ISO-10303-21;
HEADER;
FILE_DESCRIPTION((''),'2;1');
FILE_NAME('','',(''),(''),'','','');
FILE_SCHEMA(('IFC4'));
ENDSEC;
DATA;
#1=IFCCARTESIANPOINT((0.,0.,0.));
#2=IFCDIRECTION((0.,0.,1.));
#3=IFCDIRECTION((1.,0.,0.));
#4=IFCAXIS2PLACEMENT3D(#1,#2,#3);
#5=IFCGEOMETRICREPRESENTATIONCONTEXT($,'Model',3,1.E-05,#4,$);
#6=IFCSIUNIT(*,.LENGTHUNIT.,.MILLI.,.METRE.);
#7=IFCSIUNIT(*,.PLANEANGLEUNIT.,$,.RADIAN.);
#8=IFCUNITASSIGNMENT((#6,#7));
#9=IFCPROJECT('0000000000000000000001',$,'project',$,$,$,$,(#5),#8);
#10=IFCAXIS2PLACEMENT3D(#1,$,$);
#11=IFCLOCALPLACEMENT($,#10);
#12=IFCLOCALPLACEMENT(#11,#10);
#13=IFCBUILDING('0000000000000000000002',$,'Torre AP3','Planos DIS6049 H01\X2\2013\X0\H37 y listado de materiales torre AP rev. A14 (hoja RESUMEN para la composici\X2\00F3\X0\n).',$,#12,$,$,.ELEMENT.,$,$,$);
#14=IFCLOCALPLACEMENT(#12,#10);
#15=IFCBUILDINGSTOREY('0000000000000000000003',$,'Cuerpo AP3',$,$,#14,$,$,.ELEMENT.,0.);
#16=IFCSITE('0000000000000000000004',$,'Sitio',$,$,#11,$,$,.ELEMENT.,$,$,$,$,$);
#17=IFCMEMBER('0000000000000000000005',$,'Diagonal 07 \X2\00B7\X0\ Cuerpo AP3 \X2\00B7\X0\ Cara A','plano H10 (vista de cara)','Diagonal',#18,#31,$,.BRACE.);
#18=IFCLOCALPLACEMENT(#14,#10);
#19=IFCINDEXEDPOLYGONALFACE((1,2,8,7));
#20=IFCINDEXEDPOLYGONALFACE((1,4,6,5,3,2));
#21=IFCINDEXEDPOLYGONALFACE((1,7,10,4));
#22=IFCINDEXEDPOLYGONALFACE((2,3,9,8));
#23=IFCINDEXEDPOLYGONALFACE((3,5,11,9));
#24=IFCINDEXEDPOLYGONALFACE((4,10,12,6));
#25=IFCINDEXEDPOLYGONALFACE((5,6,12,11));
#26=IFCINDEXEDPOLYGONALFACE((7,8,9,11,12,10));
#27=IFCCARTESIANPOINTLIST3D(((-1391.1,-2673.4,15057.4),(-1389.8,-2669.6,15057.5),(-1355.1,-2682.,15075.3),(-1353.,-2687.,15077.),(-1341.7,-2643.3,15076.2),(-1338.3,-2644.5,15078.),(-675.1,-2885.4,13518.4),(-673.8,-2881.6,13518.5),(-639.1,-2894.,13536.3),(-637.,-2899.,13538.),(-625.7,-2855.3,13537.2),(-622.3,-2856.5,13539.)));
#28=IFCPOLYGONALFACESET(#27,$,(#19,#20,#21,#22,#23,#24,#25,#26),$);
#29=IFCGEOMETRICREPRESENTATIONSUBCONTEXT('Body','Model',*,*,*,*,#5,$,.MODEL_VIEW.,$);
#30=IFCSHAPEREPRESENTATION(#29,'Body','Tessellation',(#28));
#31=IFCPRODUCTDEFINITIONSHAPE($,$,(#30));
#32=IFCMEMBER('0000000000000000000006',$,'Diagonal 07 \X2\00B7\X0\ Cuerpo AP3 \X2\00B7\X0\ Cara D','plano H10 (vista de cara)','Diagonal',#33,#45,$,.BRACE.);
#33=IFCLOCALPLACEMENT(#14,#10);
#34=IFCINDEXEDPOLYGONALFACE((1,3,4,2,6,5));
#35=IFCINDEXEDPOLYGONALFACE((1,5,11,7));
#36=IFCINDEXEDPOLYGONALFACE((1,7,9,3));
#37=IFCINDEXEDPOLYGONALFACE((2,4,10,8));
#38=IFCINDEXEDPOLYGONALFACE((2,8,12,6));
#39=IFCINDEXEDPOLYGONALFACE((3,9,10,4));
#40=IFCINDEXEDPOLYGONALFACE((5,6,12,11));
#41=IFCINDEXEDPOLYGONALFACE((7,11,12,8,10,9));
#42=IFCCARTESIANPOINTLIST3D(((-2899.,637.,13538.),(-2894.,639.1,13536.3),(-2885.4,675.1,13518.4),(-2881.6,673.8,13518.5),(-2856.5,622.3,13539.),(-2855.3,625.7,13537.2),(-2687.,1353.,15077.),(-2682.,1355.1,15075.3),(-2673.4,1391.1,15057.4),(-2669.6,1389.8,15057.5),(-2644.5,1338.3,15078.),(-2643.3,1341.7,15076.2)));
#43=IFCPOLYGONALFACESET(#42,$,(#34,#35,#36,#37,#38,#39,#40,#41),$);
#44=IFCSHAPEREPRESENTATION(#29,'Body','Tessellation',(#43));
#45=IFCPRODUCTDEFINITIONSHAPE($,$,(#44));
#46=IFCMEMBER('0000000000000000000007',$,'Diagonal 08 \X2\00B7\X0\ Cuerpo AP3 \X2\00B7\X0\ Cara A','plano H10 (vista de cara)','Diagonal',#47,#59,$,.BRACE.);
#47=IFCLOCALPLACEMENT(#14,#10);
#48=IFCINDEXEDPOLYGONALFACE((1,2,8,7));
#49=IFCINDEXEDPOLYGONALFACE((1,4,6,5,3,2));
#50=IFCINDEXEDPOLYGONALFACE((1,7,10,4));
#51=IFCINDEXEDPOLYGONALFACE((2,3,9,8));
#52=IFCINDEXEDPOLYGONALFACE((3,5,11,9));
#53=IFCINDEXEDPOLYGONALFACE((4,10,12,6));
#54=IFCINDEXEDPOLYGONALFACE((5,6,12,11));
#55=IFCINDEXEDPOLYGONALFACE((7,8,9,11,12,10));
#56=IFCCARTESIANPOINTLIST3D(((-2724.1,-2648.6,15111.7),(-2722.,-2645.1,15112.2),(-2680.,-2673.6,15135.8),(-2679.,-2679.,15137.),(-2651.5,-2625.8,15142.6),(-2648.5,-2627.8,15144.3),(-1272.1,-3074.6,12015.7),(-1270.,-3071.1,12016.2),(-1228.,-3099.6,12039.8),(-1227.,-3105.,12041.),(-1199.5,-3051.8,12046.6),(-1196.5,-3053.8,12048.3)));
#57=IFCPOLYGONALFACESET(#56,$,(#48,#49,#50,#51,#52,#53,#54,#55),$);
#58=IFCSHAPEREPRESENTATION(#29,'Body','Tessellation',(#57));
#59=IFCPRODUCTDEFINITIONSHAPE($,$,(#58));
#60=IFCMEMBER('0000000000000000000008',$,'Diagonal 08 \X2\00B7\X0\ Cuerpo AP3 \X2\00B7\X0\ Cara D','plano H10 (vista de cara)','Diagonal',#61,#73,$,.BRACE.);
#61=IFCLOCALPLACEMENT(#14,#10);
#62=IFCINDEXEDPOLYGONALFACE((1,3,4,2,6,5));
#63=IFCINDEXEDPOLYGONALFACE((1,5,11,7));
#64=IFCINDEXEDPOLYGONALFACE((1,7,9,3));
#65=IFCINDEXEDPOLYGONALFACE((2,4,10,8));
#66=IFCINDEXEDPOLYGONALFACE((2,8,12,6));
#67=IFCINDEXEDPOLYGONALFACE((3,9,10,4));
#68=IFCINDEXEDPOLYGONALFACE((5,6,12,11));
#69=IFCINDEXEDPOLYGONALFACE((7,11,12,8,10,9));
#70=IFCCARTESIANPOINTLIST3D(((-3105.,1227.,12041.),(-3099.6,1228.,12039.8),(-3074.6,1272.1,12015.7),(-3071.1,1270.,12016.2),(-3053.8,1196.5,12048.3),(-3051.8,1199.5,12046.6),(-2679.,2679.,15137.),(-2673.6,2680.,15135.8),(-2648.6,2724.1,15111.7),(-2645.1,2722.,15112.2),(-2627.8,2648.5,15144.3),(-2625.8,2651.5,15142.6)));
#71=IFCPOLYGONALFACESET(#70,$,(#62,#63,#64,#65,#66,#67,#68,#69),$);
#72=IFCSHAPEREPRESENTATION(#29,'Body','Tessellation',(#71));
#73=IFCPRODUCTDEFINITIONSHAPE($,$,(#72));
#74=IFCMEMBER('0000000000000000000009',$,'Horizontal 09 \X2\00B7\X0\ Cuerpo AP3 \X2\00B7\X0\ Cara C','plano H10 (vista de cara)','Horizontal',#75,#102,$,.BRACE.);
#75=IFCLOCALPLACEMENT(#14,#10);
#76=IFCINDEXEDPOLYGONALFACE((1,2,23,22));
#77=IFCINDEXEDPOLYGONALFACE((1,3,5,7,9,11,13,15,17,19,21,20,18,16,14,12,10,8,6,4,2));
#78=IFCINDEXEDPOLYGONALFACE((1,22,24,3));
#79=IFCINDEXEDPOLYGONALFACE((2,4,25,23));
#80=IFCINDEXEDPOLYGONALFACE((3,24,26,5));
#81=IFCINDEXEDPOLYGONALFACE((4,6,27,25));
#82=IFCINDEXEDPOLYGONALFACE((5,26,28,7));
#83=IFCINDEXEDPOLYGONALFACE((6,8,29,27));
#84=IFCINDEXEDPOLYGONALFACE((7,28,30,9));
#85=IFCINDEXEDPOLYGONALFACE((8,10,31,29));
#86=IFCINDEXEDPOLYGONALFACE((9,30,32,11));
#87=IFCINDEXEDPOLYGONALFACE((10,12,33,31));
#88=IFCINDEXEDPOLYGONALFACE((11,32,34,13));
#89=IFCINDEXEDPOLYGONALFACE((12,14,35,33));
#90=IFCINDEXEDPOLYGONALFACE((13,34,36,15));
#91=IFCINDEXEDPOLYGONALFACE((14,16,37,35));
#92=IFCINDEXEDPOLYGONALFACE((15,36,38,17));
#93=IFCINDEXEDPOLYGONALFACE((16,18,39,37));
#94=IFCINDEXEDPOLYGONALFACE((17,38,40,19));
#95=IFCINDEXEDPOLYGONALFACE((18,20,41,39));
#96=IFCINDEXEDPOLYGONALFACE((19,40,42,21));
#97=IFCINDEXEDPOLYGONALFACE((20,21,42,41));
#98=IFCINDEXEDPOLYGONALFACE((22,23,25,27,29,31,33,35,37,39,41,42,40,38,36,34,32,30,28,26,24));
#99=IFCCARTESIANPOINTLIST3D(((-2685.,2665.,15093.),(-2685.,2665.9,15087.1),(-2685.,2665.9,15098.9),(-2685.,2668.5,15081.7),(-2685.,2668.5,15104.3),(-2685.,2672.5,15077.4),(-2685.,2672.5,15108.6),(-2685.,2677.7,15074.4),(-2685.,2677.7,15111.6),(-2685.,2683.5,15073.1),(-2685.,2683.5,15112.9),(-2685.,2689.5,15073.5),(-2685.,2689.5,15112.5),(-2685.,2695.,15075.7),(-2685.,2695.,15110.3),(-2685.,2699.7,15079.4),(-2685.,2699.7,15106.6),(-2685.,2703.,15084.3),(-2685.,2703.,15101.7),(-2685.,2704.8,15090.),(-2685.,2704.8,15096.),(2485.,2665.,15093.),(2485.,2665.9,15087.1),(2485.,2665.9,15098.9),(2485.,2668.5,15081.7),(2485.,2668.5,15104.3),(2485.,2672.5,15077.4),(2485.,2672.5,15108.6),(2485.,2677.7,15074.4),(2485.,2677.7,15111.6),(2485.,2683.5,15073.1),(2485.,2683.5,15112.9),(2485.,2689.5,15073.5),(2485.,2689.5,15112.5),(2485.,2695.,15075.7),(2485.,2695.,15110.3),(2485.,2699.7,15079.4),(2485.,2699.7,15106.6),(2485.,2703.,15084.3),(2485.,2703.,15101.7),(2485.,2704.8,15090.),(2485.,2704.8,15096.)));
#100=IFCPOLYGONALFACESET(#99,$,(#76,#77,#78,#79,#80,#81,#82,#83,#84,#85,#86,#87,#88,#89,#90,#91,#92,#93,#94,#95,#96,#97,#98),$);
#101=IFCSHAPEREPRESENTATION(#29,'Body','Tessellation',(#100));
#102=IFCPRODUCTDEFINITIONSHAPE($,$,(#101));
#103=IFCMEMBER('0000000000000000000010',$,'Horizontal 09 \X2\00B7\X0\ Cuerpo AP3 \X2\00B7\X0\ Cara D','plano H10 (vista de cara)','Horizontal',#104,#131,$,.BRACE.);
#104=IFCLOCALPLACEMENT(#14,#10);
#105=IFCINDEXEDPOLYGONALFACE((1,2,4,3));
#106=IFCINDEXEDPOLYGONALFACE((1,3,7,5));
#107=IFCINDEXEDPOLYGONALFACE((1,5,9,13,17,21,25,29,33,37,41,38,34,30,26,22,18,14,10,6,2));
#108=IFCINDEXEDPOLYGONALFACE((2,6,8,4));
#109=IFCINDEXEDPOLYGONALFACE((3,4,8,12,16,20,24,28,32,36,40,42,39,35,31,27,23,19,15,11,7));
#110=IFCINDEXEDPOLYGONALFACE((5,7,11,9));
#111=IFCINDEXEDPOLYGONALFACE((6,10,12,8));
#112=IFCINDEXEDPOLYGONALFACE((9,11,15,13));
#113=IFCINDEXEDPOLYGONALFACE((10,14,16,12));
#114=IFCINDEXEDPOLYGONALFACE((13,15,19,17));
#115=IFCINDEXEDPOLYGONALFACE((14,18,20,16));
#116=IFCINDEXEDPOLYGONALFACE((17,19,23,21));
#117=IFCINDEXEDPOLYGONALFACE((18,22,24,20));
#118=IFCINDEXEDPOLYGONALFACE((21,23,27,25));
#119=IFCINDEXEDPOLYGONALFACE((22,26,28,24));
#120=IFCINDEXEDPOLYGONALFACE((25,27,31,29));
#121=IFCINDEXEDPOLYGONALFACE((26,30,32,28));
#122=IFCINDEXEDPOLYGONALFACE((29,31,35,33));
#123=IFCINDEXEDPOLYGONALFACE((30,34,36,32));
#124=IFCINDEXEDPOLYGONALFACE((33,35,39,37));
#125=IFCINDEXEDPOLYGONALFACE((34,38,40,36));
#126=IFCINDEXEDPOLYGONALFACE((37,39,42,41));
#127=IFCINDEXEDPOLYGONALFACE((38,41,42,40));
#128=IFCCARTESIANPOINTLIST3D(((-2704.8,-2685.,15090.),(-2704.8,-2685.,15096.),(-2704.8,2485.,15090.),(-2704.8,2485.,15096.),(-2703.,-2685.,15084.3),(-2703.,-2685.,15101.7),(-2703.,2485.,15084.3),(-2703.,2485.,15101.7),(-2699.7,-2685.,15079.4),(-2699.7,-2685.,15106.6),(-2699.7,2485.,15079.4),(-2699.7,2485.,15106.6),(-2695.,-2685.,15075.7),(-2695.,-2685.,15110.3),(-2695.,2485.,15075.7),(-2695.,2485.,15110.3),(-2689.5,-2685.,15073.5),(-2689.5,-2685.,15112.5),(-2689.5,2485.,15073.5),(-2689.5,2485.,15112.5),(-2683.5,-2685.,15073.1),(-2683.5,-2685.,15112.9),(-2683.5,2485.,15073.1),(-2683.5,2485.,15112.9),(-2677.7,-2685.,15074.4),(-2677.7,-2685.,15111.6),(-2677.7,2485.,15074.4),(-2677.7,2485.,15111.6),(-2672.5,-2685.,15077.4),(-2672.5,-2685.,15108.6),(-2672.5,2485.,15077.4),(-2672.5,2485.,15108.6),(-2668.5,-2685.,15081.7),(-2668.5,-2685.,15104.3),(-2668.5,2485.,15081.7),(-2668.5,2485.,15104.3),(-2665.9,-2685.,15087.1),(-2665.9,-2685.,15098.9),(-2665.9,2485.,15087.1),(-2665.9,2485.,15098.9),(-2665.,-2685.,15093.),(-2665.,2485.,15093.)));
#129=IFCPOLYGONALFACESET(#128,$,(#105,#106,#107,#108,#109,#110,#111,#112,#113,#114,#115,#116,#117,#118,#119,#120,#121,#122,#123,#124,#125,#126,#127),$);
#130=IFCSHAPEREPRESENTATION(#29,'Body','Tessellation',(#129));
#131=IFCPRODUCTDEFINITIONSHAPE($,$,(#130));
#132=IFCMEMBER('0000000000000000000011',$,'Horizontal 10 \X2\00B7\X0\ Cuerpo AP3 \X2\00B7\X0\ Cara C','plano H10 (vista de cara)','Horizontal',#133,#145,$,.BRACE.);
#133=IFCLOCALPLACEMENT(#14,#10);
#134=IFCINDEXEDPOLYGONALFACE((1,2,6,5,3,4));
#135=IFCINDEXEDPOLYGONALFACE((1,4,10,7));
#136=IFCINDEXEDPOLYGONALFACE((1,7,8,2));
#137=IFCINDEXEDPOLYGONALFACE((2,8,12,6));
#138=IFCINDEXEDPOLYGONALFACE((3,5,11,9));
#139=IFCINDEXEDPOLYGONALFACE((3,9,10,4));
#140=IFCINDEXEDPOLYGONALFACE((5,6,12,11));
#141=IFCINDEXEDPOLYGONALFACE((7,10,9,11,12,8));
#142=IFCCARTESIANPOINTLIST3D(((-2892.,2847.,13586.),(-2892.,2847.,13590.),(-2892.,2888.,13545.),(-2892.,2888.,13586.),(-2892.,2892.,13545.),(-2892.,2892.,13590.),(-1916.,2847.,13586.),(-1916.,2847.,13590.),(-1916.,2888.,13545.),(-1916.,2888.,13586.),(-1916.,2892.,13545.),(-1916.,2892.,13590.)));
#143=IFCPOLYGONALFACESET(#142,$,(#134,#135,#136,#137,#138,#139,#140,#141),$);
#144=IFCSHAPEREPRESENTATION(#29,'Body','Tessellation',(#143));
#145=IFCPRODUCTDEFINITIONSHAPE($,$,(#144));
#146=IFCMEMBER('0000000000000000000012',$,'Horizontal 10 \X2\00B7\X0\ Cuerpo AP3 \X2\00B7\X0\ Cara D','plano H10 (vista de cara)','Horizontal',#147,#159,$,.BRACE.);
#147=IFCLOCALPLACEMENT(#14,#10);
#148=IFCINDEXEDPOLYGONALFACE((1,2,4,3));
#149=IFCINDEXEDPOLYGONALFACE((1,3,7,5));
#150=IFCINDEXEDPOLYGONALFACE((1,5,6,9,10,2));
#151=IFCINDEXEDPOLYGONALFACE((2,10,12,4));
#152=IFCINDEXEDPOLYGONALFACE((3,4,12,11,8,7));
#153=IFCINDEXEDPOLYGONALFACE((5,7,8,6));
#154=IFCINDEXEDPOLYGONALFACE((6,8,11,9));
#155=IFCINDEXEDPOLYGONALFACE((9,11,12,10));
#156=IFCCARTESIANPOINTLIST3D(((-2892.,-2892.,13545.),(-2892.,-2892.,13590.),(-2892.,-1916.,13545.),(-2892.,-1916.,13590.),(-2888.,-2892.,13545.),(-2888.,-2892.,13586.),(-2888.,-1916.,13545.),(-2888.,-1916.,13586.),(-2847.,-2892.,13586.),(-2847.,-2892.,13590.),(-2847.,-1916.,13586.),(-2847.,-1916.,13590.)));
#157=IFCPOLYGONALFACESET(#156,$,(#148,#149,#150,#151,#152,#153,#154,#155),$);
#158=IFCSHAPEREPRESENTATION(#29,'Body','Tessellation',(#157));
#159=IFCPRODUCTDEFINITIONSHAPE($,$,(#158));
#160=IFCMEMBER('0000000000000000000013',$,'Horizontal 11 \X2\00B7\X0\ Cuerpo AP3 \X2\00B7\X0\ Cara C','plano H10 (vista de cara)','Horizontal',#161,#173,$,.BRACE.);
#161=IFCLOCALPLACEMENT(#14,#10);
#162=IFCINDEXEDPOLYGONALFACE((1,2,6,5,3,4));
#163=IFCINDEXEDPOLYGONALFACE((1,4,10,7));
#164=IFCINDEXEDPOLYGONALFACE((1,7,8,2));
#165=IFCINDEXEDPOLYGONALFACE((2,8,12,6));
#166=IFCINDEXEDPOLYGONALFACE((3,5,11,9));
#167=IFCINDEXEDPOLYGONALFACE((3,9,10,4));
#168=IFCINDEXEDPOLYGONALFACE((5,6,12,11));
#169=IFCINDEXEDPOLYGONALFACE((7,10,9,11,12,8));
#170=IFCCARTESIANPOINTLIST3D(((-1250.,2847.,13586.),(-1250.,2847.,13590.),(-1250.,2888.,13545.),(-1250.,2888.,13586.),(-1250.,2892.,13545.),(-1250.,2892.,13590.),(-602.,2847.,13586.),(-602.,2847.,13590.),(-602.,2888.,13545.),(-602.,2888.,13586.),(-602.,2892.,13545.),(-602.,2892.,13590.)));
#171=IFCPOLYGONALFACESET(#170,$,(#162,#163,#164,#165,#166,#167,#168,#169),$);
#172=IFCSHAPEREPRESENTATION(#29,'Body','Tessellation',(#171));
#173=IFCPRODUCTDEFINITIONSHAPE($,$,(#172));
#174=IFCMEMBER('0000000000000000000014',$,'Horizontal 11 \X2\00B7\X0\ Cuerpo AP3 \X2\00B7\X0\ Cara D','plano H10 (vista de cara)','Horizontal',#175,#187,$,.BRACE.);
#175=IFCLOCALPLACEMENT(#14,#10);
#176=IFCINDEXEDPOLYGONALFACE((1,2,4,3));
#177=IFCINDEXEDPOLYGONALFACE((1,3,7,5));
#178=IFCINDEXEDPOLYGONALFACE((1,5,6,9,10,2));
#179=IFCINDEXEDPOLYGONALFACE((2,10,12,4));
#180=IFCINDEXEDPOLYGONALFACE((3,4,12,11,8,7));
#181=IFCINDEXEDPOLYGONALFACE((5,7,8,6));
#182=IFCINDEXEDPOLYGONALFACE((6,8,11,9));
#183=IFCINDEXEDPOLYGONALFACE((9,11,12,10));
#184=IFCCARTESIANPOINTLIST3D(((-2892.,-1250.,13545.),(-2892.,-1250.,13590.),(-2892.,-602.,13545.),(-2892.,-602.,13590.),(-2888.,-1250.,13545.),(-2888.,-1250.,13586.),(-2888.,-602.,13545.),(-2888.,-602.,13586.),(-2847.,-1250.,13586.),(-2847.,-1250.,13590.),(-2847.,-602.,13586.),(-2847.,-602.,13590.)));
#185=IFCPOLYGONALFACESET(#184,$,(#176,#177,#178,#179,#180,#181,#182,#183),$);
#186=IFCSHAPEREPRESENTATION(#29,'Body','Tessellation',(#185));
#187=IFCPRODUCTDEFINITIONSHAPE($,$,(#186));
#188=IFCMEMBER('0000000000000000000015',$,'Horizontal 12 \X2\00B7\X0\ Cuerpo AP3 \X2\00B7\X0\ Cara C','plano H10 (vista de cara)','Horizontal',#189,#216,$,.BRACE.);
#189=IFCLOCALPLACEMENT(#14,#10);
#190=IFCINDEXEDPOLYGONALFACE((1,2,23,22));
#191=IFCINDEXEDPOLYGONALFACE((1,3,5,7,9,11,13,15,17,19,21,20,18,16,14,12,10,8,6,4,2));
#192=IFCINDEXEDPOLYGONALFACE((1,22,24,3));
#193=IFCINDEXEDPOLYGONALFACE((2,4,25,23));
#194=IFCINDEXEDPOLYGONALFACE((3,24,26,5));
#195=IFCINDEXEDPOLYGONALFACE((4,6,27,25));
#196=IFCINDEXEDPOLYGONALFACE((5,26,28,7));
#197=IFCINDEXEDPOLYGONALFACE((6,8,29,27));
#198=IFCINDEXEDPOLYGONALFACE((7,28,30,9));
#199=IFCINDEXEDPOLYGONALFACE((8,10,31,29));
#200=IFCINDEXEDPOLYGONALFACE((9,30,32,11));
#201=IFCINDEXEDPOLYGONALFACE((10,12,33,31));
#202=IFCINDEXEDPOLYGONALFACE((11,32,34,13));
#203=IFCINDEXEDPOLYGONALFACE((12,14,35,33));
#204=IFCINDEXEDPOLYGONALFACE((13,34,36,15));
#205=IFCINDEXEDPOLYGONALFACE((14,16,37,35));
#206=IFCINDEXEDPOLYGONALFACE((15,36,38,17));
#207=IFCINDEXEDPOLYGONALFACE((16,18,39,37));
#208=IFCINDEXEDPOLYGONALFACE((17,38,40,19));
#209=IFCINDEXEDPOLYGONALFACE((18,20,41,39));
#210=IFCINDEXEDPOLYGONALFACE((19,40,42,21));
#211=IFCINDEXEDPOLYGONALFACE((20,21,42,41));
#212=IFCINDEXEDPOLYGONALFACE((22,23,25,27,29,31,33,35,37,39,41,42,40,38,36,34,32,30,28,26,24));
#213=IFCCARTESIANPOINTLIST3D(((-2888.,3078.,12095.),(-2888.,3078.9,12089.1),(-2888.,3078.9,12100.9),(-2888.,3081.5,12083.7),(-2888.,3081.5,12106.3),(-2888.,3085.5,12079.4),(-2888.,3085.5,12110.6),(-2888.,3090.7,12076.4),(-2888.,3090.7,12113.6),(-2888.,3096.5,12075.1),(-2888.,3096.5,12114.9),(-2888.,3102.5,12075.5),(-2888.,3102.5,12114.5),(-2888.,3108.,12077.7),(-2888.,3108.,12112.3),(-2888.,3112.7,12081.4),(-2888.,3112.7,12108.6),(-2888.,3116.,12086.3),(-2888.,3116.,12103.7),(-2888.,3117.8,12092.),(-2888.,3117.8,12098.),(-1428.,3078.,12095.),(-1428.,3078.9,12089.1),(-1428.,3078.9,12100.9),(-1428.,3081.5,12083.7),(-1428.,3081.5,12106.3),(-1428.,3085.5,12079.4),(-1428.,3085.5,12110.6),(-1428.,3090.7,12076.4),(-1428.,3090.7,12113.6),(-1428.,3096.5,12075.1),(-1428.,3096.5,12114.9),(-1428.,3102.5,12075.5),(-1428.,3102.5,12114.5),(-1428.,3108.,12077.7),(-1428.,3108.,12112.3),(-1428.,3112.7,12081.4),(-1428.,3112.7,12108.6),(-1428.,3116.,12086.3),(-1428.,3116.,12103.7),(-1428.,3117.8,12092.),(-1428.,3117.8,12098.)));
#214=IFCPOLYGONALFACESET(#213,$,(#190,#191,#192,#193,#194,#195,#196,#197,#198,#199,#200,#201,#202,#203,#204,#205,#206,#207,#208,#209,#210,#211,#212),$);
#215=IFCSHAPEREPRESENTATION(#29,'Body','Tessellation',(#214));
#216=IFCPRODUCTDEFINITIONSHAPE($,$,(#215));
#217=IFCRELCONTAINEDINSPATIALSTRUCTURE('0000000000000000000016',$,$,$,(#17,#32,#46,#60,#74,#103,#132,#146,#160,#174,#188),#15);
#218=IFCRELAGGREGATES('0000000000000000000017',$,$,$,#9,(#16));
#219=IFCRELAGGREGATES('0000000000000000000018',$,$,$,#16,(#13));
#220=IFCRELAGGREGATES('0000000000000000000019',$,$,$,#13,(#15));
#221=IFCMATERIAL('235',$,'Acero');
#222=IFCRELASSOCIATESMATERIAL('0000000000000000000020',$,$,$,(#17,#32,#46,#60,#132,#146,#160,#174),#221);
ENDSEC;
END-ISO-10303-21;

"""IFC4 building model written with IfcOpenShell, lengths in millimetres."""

from ifc_helpers import new_model, si_unit, frame, frame_2d, origin, origin_with_axes, place, context, subcontext, project, spatial, circle, l_section, extrude, material, element, save


model = new_model("IFC4")

# Units and contexts
model_context = context("Model", 3, precision=1e-05, world=origin_with_axes())
body_context = subcontext(model_context, "Body", "Model", "MODEL_VIEW")
ifc_project = project(units=[si_unit("LENGTHUNIT", "METRE", prefix="MILLI"), si_unit("PLANEANGLEUNIT", "RADIAN")], contexts=[model_context])

# Site, building, storey
site_placement = place(None, origin())
site = spatial("IfcSite", under=ifc_project, at=site_placement, Name="Sitio", CompositionType="ELEMENT")
building_placement = place(site_placement, origin())
building = spatial("IfcBuilding", under=site, at=building_placement, Name="Torre AP3", Description="Planos DIS6049 H01–H37 y listado de materiales torre AP rev. A14 (hoja RESUMEN para la composición).", CompositionType="ELEMENT")
storey_placement = place(building_placement, origin())
storey = spatial("IfcBuildingStorey", under=building, at=storey_placement, Name="Cuerpo AP3", CompositionType="ELEMENT", Elevation=0.0)

# Members
ifc_material_1 = material(Name="235", Category="Acero")
for number, where, z_axis, x_axis, name in (
    (1, (-637.0, -2899.0, 13538.0), (-0.418569, 0.123934, 0.899689), (0.325752, 0.945214, 0.021347), "Diagonal 07 · Cuerpo AP3 · Cara A"),
    (2, (-2899.0, 637.0, 13538.0), (0.123934, 0.418569, 0.899689), (0.945214, -0.325752, 0.021347), "Diagonal 07 · Cuerpo AP3 · Cara D"),
):
    element("IfcMember", number, at=place(storey_placement, frame(where, z_axis=z_axis, x_axis=x_axis)), inside=storey, material=ifc_material_1, Name=name, Description="plano H10 (vista de cara)", ObjectType="Diagonal", PredefinedType="BRACE", context=body_context, shape_type="SweptSolid", body=[
        extrude(l_section(Depth=45.0, Width=45.0, Thickness=4.0, at=frame_2d((22.5, 22.5))), None, (0.0, 0.0, 1.0), 1710.6),
    ])
for number, where, z_axis, x_axis, name in (
    (3, (-1227.0, -3105.0, 12041.0), (-0.421357, 0.123621, 0.89843), (0.507994, 0.852834, 0.120898), "Diagonal 08 · Cuerpo AP3 · Cara A"),
    (4, (-3105.0, 1227.0, 12041.0), (0.123621, 0.421357, 0.89843), (0.852834, -0.507994, 0.120898), "Diagonal 08 · Cuerpo AP3 · Cara D"),
):
    element("IfcMember", number, at=place(storey_placement, frame(where, z_axis=z_axis, x_axis=x_axis)), inside=storey, material=ifc_material_1, Name=name, Description="plano H10 (vista de cara)", ObjectType="Diagonal", PredefinedType="BRACE", context=body_context, shape_type="SweptSolid", body=[
        extrude(l_section(Depth=60.0, Width=60.0, Thickness=4.0, at=frame_2d((30.0, 30.0))), None, (0.0, 0.0, 1.0), 3446.0),
    ])
for number, where, z_axis, x_axis, name in (
    (5, (-2685.0, 2685.0, 15093.0), (1.0, 0.0, 0.0), (0.0, -1.0, 0.0), "Horizontal 09 · Cuerpo AP3 · Cara C"),
    (6, (-2685.0, -2685.0, 15093.0), (0.0, 1.0, 0.0), (1.0, 0.0, 0.0), "Horizontal 09 · Cuerpo AP3 · Cara D"),
):
    element("IfcMember", number, at=place(storey_placement, frame(where, z_axis=z_axis, x_axis=x_axis)), inside=storey, Name=name, Description="plano H10 (vista de cara)", ObjectType="Horizontal", PredefinedType="BRACE", context=body_context, shape_type="SweptSolid", body=[
        extrude(circle(Radius=20.0), None, (0.0, 0.0, 1.0), 5170.0),
    ])
for number, where, z_axis, x_axis, name in (
    (7, (-2892.0, 2892.0, 13590.0), (1.0, 0.0, 0.0), (0.0, -1.0, 0.0), "Horizontal 10 · Cuerpo AP3 · Cara C"),
    (8, (-2892.0, -2892.0, 13590.0), (0.0, 1.0, 0.0), (1.0, 0.0, 0.0), "Horizontal 10 · Cuerpo AP3 · Cara D"),
):
    element("IfcMember", number, at=place(storey_placement, frame(where, z_axis=z_axis, x_axis=x_axis)), inside=storey, material=ifc_material_1, Name=name, Description="plano H10 (vista de cara)", ObjectType="Horizontal", PredefinedType="BRACE", context=body_context, shape_type="SweptSolid", body=[
        extrude(l_section(Depth=45.0, Width=45.0, Thickness=4.0, at=frame_2d((22.5, 22.5))), None, (0.0, 0.0, 1.0), 976.0),
    ])
for number, where, z_axis, x_axis, name in (
    (9, (-1250.0, 2892.0, 13590.0), (1.0, 0.0, 0.0), (0.0, -1.0, 0.0), "Horizontal 11 · Cuerpo AP3 · Cara C"),
    (10, (-2892.0, -1250.0, 13590.0), (0.0, 1.0, 0.0), (1.0, 0.0, 0.0), "Horizontal 11 · Cuerpo AP3 · Cara D"),
):
    element("IfcMember", number, at=place(storey_placement, frame(where, z_axis=z_axis, x_axis=x_axis)), inside=storey, material=ifc_material_1, Name=name, Description="plano H10 (vista de cara)", ObjectType="Horizontal", PredefinedType="BRACE", context=body_context, shape_type="SweptSolid", body=[
        extrude(l_section(Depth=45.0, Width=45.0, Thickness=4.0, at=frame_2d((22.5, 22.5))), None, (0.0, 0.0, 1.0), 648.0),
    ])
for number, where, z_axis, x_axis, name in (
    (11, (-2888.0, 3098.0, 12095.0), (1.0, 0.0, 0.0), (0.0, -1.0, 0.0), "Horizontal 12 · Cuerpo AP3 · Cara C"),
):
    element("IfcMember", number, at=place(storey_placement, frame(where, z_axis=z_axis, x_axis=x_axis)), inside=storey, Name=name, Description="plano H10 (vista de cara)", ObjectType="Horizontal", PredefinedType="BRACE", context=body_context, shape_type="SweptSolid", body=[
        extrude(circle(Radius=20.0), None, (0.0, 0.0, 1.0), 1460.0),
    ])

save(model, "model.ifc")
